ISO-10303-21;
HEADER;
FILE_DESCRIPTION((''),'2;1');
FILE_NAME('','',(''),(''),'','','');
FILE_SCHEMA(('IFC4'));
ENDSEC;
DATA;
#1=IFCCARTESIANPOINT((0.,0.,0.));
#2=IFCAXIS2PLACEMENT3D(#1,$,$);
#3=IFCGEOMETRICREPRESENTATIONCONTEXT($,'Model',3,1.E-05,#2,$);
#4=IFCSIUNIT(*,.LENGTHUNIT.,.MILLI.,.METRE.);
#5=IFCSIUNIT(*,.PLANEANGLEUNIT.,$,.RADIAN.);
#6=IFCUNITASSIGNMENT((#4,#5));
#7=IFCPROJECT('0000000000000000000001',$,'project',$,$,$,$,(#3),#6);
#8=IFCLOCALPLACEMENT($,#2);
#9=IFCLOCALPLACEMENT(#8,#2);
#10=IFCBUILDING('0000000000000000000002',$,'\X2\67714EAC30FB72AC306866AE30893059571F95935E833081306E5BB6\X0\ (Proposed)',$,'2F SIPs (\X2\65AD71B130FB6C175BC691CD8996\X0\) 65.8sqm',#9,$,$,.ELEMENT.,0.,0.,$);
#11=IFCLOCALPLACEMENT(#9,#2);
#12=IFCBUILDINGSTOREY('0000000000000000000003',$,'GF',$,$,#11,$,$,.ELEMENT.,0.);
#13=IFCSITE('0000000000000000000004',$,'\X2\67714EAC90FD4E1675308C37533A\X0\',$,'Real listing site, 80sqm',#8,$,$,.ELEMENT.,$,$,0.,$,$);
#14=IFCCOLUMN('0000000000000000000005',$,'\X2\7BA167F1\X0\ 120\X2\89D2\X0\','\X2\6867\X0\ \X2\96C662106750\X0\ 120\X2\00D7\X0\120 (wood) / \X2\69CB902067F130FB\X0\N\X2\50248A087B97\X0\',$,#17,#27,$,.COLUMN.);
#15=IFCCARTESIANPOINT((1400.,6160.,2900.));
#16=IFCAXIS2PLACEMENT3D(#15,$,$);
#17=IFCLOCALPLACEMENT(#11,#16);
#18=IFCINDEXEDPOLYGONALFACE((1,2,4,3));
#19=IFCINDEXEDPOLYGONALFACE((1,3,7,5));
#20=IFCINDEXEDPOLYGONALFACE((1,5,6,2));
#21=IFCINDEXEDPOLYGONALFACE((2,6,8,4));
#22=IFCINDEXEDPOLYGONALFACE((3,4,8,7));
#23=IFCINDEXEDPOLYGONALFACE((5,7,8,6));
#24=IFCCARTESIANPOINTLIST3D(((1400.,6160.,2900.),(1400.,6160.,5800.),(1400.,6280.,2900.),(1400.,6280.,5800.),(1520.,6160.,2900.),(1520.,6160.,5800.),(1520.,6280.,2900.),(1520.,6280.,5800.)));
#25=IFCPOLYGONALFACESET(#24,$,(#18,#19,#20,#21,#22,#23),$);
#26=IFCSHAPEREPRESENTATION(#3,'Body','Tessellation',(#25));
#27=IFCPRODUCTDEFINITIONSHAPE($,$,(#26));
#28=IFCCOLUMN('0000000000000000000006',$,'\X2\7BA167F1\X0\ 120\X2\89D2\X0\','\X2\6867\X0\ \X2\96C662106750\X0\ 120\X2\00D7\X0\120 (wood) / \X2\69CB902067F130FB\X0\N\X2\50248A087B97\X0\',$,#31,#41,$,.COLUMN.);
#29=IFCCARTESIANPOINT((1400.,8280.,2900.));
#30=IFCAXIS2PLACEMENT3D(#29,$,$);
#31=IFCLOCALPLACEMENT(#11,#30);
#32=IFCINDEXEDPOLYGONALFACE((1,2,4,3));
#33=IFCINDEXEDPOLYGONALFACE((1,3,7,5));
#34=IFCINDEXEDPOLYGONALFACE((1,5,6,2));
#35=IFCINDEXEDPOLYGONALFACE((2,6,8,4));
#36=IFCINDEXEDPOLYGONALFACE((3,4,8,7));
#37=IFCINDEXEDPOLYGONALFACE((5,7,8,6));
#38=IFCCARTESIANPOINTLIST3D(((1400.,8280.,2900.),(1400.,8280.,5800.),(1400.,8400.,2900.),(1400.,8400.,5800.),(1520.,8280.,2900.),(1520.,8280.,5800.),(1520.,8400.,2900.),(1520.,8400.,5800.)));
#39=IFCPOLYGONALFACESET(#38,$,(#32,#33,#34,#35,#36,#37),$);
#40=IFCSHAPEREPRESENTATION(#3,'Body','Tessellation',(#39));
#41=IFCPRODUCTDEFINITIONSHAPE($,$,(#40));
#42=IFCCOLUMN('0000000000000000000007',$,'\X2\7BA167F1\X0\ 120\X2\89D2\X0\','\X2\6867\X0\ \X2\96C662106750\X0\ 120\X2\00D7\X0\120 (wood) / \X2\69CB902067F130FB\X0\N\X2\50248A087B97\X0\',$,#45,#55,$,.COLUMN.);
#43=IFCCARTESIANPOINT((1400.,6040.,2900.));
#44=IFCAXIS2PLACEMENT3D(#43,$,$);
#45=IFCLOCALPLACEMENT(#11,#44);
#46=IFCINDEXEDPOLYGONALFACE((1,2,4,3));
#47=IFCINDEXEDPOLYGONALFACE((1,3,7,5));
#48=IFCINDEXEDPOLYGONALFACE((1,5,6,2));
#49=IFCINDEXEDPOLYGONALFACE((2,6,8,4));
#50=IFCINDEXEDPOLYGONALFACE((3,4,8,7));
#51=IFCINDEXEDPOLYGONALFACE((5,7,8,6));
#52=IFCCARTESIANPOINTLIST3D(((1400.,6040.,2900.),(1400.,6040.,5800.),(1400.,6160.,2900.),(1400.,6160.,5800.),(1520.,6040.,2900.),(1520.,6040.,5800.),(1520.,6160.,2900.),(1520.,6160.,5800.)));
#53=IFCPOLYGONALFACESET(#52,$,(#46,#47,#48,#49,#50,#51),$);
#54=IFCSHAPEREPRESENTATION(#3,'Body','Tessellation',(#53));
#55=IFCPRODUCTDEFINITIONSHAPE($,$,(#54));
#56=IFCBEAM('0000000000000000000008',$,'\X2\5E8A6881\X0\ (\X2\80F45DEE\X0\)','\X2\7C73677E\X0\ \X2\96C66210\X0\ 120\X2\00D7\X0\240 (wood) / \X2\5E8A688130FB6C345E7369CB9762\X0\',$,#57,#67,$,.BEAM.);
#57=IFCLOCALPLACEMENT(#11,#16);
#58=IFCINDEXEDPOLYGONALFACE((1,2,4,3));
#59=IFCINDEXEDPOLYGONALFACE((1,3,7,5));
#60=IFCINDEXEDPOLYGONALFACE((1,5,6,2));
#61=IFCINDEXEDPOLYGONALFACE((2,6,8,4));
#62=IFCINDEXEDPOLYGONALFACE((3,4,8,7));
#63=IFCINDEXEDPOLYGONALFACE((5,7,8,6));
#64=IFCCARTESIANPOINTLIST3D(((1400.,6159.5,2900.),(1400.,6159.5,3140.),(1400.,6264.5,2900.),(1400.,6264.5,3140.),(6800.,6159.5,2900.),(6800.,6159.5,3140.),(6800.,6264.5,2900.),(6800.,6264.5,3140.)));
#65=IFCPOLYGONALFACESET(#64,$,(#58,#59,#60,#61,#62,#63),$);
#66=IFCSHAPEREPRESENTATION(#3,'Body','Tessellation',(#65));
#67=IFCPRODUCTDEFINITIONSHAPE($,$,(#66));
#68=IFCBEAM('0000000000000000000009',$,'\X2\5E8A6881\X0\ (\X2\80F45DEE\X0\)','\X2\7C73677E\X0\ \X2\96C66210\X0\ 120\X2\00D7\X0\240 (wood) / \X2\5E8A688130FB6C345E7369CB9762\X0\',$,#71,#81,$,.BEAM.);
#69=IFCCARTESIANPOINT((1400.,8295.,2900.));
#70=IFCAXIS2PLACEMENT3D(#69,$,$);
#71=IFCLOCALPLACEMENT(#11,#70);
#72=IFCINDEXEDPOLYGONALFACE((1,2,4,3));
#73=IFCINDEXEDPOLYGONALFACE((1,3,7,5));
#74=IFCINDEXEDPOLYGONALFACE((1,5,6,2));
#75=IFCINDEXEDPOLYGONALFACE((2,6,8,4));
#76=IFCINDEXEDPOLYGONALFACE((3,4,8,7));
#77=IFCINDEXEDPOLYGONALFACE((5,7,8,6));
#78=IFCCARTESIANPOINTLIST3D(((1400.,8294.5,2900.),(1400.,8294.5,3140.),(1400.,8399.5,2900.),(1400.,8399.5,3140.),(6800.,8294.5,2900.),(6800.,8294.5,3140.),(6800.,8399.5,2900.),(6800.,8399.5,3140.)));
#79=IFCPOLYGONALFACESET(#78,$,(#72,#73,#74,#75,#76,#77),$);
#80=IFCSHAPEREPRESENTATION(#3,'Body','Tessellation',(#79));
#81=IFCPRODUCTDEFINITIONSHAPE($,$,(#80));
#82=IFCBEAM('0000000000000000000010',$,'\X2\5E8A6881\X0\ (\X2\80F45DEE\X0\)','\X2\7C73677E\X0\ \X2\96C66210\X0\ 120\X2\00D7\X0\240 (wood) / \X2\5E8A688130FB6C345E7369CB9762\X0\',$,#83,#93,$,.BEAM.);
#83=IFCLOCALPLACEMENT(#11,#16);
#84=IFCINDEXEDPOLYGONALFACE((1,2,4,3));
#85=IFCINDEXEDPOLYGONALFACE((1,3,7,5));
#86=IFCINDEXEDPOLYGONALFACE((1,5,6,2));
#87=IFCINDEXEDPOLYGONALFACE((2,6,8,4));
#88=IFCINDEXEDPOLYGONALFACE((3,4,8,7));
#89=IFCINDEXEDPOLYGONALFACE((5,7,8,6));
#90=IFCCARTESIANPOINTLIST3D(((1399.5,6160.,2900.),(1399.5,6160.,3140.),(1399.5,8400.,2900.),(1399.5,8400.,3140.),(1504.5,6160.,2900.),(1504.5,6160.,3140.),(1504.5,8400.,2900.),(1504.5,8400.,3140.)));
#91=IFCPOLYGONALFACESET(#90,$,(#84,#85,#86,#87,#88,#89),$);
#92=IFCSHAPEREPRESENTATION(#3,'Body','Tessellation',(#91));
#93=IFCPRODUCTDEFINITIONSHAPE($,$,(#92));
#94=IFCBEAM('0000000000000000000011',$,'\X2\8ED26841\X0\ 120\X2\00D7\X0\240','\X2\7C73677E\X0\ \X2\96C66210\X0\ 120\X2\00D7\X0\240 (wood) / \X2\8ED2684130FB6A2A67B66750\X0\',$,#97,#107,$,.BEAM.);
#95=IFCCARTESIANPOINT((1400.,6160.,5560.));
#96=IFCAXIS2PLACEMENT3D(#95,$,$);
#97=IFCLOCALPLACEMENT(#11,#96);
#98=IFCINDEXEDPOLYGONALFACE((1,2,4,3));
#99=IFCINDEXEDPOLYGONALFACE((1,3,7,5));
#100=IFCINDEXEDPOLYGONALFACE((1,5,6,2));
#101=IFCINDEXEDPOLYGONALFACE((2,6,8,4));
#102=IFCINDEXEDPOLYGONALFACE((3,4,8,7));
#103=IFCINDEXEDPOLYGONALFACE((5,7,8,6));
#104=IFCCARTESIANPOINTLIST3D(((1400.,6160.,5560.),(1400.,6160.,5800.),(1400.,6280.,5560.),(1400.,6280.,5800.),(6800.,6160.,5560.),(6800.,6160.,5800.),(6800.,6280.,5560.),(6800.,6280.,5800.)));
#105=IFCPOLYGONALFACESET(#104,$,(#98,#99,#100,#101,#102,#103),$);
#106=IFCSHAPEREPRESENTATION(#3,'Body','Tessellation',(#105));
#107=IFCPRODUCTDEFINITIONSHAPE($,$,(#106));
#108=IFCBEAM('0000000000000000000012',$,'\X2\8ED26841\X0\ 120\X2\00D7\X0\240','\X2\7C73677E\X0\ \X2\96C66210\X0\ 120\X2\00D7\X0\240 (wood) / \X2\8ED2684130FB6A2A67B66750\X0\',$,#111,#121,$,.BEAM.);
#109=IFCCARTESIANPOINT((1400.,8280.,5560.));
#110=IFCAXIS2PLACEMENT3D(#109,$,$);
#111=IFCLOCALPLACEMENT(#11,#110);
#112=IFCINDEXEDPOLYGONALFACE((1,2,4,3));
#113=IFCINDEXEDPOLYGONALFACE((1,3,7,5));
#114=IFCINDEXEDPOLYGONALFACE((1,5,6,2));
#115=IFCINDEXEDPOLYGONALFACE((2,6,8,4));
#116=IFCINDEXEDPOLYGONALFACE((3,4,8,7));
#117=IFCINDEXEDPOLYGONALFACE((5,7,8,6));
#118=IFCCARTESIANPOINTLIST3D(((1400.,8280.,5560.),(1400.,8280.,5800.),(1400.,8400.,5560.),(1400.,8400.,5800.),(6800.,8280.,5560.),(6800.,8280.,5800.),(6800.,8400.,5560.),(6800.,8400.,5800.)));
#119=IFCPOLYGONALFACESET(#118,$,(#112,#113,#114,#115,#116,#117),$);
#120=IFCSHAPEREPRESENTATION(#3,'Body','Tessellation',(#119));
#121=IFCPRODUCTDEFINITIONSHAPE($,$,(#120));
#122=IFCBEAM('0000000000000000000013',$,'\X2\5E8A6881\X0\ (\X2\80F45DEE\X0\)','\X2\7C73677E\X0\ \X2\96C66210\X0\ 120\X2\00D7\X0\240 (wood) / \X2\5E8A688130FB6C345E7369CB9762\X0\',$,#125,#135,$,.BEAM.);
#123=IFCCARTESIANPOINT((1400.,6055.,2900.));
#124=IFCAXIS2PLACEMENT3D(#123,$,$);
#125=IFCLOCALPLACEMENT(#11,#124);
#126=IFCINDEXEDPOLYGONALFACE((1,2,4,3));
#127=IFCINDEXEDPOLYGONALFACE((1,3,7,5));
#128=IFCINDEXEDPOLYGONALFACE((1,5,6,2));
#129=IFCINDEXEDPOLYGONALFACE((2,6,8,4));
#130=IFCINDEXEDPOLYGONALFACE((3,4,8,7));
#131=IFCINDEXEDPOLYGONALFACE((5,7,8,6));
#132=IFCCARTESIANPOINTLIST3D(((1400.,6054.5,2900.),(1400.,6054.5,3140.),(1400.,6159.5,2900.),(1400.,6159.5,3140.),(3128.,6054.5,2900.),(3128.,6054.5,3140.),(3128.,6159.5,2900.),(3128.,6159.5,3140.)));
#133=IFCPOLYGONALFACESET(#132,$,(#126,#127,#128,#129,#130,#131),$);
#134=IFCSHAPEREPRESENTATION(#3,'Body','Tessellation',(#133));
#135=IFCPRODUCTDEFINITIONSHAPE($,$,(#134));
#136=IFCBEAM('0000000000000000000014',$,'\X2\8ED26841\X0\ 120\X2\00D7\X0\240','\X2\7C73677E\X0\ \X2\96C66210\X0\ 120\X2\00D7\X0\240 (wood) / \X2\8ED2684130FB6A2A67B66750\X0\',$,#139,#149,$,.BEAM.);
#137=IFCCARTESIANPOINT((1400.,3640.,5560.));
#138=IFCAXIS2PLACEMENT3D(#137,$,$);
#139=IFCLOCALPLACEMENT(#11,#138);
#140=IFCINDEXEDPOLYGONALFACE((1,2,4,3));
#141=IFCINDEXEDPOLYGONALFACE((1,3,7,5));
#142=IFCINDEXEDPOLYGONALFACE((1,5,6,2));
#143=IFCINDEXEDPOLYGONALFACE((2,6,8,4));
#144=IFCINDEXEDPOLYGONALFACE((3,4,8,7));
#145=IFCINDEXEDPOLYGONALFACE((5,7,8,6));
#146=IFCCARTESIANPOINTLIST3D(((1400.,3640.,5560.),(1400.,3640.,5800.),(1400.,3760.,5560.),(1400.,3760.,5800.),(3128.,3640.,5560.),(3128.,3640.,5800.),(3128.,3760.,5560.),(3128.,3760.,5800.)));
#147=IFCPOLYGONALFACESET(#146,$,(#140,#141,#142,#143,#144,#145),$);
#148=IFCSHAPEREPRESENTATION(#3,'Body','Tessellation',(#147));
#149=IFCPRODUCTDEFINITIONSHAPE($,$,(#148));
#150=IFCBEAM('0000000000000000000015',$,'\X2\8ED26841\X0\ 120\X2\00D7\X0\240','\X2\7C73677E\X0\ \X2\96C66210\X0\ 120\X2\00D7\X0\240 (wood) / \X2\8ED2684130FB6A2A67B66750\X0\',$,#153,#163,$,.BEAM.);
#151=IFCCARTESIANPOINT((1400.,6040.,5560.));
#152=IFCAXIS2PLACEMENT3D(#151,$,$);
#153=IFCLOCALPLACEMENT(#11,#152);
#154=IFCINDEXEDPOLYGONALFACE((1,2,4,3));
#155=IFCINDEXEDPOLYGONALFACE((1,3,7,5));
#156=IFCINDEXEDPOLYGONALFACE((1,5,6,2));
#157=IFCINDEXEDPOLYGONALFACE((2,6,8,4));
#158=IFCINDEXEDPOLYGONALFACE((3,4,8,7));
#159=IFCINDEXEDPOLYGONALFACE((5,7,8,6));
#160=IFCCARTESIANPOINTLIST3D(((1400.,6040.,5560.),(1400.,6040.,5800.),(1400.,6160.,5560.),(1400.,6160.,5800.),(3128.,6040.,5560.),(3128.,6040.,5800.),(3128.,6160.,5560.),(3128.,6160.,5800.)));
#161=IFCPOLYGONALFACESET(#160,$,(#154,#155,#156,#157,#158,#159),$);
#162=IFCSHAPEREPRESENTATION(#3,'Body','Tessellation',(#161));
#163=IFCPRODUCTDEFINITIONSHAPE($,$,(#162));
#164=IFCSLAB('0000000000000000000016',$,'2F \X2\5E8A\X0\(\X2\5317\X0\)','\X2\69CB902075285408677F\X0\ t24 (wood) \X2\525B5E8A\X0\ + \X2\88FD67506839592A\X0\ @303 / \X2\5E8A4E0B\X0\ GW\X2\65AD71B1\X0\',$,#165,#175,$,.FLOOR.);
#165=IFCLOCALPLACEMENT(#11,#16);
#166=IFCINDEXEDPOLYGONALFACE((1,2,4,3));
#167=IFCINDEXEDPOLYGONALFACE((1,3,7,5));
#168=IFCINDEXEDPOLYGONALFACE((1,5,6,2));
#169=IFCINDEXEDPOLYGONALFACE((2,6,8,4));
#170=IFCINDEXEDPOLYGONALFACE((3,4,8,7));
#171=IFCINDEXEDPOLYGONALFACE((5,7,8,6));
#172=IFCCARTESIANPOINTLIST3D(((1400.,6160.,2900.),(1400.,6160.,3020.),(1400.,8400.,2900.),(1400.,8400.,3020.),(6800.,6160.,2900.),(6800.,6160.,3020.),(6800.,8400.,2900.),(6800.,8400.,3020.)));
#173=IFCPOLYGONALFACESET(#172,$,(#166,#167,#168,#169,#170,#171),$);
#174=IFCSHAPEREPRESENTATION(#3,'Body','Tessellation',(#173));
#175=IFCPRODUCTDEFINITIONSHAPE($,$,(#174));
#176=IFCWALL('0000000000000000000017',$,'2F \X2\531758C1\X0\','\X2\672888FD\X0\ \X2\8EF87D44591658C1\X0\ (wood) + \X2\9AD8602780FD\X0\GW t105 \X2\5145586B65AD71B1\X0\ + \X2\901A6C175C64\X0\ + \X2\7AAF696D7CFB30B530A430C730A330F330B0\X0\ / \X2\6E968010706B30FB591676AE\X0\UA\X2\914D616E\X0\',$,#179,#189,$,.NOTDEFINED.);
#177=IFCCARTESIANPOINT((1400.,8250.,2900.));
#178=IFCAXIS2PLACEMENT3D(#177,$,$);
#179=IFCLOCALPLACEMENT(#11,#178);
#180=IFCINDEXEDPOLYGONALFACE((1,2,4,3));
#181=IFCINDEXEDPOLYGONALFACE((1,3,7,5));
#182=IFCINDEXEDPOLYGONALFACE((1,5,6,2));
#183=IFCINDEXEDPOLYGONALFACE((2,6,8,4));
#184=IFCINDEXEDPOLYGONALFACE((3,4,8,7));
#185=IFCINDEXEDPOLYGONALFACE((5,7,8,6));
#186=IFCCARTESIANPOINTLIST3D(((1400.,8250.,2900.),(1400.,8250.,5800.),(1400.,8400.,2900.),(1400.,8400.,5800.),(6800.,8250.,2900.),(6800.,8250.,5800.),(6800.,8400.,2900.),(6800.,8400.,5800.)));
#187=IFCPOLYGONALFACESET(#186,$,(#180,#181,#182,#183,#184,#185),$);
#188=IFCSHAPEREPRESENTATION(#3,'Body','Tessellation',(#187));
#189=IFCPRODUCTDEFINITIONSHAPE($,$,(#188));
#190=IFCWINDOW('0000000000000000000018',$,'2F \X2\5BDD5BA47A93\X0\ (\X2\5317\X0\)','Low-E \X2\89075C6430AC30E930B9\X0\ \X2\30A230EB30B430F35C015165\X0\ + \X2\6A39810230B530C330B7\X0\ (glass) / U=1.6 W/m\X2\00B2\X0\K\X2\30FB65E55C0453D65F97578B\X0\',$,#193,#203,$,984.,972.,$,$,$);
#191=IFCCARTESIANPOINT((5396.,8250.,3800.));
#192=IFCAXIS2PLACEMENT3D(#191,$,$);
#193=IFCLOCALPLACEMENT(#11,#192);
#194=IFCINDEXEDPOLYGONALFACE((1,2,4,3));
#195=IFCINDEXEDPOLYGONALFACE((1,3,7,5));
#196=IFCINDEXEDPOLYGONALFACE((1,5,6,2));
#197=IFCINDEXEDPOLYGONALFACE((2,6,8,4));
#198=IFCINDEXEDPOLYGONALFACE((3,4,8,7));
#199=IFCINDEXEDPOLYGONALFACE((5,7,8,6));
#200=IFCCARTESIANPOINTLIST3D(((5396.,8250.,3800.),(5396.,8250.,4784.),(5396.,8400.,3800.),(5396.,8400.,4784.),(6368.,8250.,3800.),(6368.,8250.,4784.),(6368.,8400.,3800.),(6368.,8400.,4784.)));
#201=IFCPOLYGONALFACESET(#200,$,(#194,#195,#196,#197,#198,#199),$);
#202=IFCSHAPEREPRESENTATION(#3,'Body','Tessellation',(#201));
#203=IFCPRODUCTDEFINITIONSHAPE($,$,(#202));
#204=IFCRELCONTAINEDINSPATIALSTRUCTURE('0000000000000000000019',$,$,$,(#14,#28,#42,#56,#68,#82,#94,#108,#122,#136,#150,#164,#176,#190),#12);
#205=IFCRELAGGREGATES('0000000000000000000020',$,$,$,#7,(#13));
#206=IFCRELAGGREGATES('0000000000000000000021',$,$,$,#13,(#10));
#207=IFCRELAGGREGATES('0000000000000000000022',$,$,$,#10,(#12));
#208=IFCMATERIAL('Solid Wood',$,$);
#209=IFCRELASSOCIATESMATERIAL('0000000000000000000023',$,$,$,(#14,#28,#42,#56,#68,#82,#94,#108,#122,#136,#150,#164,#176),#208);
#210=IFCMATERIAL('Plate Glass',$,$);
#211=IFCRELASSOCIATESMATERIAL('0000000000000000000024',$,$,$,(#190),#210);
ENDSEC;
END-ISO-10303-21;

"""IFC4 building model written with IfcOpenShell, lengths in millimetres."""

from ifc_helpers import new_model, si_unit, frame, frame_2d, origin, place, context, project, spatial, rectangle, extrude, material, element, fill, save


model = new_model("IFC4")

# Units and contexts
model_context = context("Model", 3, precision=1e-05, world=origin())
ifc_project = project(units=[si_unit("LENGTHUNIT", "METRE", prefix="MILLI"), si_unit("PLANEANGLEUNIT", "RADIAN")], contexts=[model_context])

# Site, building, storey
site_placement = place(None, origin())
site = spatial("IfcSite", under=ifc_project, at=site_placement, Name="東京都世田谷区", ObjectType="Real listing site, 80sqm", CompositionType="ELEMENT", RefElevation=0.0)
building_placement = place(site_placement, origin())
building = spatial("IfcBuilding", under=site, at=building_placement, Name="東京・犬と暮らす土間広めの家 (Proposed)", ObjectType="2F SIPs (断熱・気密重視) 65.8sqm", CompositionType="ELEMENT", ElevationOfRefHeight=0.0, ElevationOfTerrain=0.0)
storey_placement = place(building_placement, origin())
storey = spatial("IfcBuildingStorey", under=building, at=storey_placement, Name="GF", CompositionType="ELEMENT", Elevation=0.0)

# Columns
ifc_material_1 = material(Name="Solid Wood")
column_1_placement = place(storey_placement, frame((1400.0, 6160.0, 2900.0)))
element("IfcColumn", 1, at=column_1_placement, inside=storey, material=ifc_material_1, Name="管柱 120角", Description="桧 集成材 120×120 (wood) / 構造柱・N値計算", PredefinedType="COLUMN", context=model_context, shape_type="SweptSolid", body=[
    extrude(rectangle(XDim=120.0, YDim=120.0, at=frame_2d((60.0, 60.0))), frame((1400.0, 6160.0, 2900.0)), (0.0, 0.0, 1.0), 2900.0),
])
column_2_placement = place(storey_placement, frame((1400.0, 8280.0, 2900.0)))
element("IfcColumn", 2, at=column_2_placement, inside=storey, material=ifc_material_1, Name="管柱 120角", Description="桧 集成材 120×120 (wood) / 構造柱・N値計算", PredefinedType="COLUMN", context=model_context, shape_type="SweptSolid", body=[
    extrude(rectangle(XDim=120.0, YDim=120.0, at=frame_2d((60.0, 60.0))), frame((1400.0, 8280.0, 2900.0)), (0.0, 0.0, 1.0), 2900.0),
])
column_3_placement = place(storey_placement, frame((1400.0, 6040.0, 2900.0)))
element("IfcColumn", 3, at=column_3_placement, inside=storey, material=ifc_material_1, Name="管柱 120角", Description="桧 集成材 120×120 (wood) / 構造柱・N値計算", PredefinedType="COLUMN", context=model_context, shape_type="SweptSolid", body=[
    extrude(rectangle(XDim=120.0, YDim=120.0, at=frame_2d((60.0, 60.0))), frame((1400.0, 6040.0, 2900.0)), (0.0, 0.0, 1.0), 2900.0),
])

# Beams
beam_1_placement = place(storey_placement, frame((1400.0, 6160.0, 2900.0)))
element("IfcBeam", 4, at=beam_1_placement, inside=storey, material=ifc_material_1, Name="床梁 (胴差)", Description="米松 集成 120×240 (wood) / 床梁・水平構面", PredefinedType="BEAM", context=model_context, shape_type="SweptSolid", body=[
    extrude(rectangle(XDim=5400.0, YDim=105.0, at=frame_2d((2700.0, 52.0))), frame((1400.0, 6160.0, 2900.0)), (0.0, 0.0, 1.0), 240.0),
])
beam_2_placement = place(storey_placement, frame((1400.0, 8295.0, 2900.0)))
element("IfcBeam", 5, at=beam_2_placement, inside=storey, material=ifc_material_1, Name="床梁 (胴差)", Description="米松 集成 120×240 (wood) / 床梁・水平構面", PredefinedType="BEAM", context=model_context, shape_type="SweptSolid", body=[
    extrude(rectangle(XDim=5400.0, YDim=105.0, at=frame_2d((2700.0, 52.0))), frame((1400.0, 8295.0, 2900.0)), (0.0, 0.0, 1.0), 240.0),
])
beam_3_placement = place(storey_placement, frame((1400.0, 6160.0, 2900.0)))
element("IfcBeam", 6, at=beam_3_placement, inside=storey, material=ifc_material_1, Name="床梁 (胴差)", Description="米松 集成 120×240 (wood) / 床梁・水平構面", PredefinedType="BEAM", context=model_context, shape_type="SweptSolid", body=[
    extrude(rectangle(XDim=105.0, YDim=2240.0, at=frame_2d((52.0, 1120.0))), frame((1400.0, 6160.0, 2900.0)), (0.0, 0.0, 1.0), 240.0),
])
beam_4_placement = place(storey_placement, frame((1400.0, 6160.0, 5560.0)))
element("IfcBeam", 7, at=beam_4_placement, inside=storey, material=ifc_material_1, Name="軒桁 120×240", Description="米松 集成 120×240 (wood) / 軒桁・横架材", PredefinedType="BEAM", context=model_context, shape_type="SweptSolid", body=[
    extrude(rectangle(XDim=5400.0, YDim=120.0, at=frame_2d((2700.0, 60.0))), frame((1400.0, 6160.0, 5560.0)), (0.0, 0.0, 1.0), 240.0),
])
beam_5_placement = place(storey_placement, frame((1400.0, 8280.0, 5560.0)))
element("IfcBeam", 8, at=beam_5_placement, inside=storey, material=ifc_material_1, Name="軒桁 120×240", Description="米松 集成 120×240 (wood) / 軒桁・横架材", PredefinedType="BEAM", context=model_context, shape_type="SweptSolid", body=[
    extrude(rectangle(XDim=5400.0, YDim=120.0, at=frame_2d((2700.0, 60.0))), frame((1400.0, 8280.0, 5560.0)), (0.0, 0.0, 1.0), 240.0),
])
beam_6_placement = place(storey_placement, frame((1400.0, 6055.0, 2900.0)))
element("IfcBeam", 9, at=beam_6_placement, inside=storey, material=ifc_material_1, Name="床梁 (胴差)", Description="米松 集成 120×240 (wood) / 床梁・水平構面", PredefinedType="BEAM", context=model_context, shape_type="SweptSolid", body=[
    extrude(rectangle(XDim=1728.0, YDim=105.0, at=frame_2d((864.0, 52.0))), frame((1400.0, 6055.0, 2900.0)), (0.0, 0.0, 1.0), 240.0),
])
beam_7_placement = place(storey_placement, frame((1400.0, 3640.0, 5560.0)))
element("IfcBeam", 10, at=beam_7_placement, inside=storey, material=ifc_material_1, Name="軒桁 120×240", Description="米松 集成 120×240 (wood) / 軒桁・横架材", PredefinedType="BEAM", context=model_context, shape_type="SweptSolid", body=[
    extrude(rectangle(XDim=1728.0, YDim=120.0, at=frame_2d((864.0, 60.0))), frame((1400.0, 3640.0, 5560.0)), (0.0, 0.0, 1.0), 240.0),
])
beam_8_placement = place(storey_placement, frame((1400.0, 6040.0, 5560.0)))
element("IfcBeam", 11, at=beam_8_placement, inside=storey, material=ifc_material_1, Name="軒桁 120×240", Description="米松 集成 120×240 (wood) / 軒桁・横架材", PredefinedType="BEAM", context=model_context, shape_type="SweptSolid", body=[
    extrude(rectangle(XDim=1728.0, YDim=120.0, at=frame_2d((864.0, 60.0))), frame((1400.0, 6040.0, 5560.0)), (0.0, 0.0, 1.0), 240.0),
])

# Slab
slab_placement = place(storey_placement, frame((1400.0, 6160.0, 2900.0)))
element("IfcSlab", 12, at=slab_placement, inside=storey, material=ifc_material_1, Name="2F 床(北)", Description="構造用合板 t24 (wood) 剛床 + 製材根太 @303 / 床下 GW断熱", PredefinedType="FLOOR", context=model_context, shape_type="SweptSolid", body=[
    extrude(rectangle(XDim=5400.0, YDim=2240.0, at=frame_2d((2700.0, 1120.0))), frame((1400.0, 6160.0, 2900.0)), (0.0, 0.0, 1.0), 120.0),
])

# Wall, opening, window
wall_placement = place(storey_placement, frame((1400.0, 8250.0, 2900.0)))
wall = element("IfcWall", 13, at=wall_placement, inside=storey, material=ifc_material_1, Name="2F 北壁", Description="木製 軸組外壁 (wood) + 高性能GW t105 充填断熱 + 通気層 + 窯業系サイディング / 準耐火・外皮UA配慮", PredefinedType="NOTDEFINED", context=model_context, shape_type="SweptSolid", body=[
    extrude(rectangle(XDim=5400.0, YDim=150.0, at=frame_2d((2700.0, 75.0))), frame((1400.0, 8250.0, 2900.0)), (0.0, 0.0, 1.0), 2900.0),
])
opening_placement = place(storey_placement, frame((5396.0, 8250.0, 3800.0)))
opening = element("IfcOpeningElement", 14, at=opening_placement, cuts=wall, PredefinedType="NOTDEFINED", context=model_context, shape_type="SweptSolid", body=[
    extrude(rectangle(XDim=972.0, YDim=150.0, at=frame_2d((486.0, 75.0))), frame((5396.0, 8250.0, 3800.0)), (0.0, 0.0, 1.0), 984.0),
])
ifc_material_2 = material(Name="Plate Glass")
window_placement = place(storey_placement, frame((5396.0, 8250.0, 3800.0)))
window = element("IfcWindow", 15, at=window_placement, inside=storey, material=ifc_material_2, Name="2F 寝室窓 (北)", Description="Low-E 複層ガラス アルゴン封入 + 樹脂サッシ (glass) / U=1.6 W/m²K・日射取得型", OverallHeight=984.0, OverallWidth=972.0, context=model_context, shape_type="SweptSolid", body=[
    extrude(rectangle(XDim=972.0, YDim=150.0, at=frame_2d((486.0, 75.0))), frame((5396.0, 8250.0, 3800.0)), (0.0, 0.0, 1.0), 984.0),
])
fill(opening, window)

save(model, "model.ifc")
